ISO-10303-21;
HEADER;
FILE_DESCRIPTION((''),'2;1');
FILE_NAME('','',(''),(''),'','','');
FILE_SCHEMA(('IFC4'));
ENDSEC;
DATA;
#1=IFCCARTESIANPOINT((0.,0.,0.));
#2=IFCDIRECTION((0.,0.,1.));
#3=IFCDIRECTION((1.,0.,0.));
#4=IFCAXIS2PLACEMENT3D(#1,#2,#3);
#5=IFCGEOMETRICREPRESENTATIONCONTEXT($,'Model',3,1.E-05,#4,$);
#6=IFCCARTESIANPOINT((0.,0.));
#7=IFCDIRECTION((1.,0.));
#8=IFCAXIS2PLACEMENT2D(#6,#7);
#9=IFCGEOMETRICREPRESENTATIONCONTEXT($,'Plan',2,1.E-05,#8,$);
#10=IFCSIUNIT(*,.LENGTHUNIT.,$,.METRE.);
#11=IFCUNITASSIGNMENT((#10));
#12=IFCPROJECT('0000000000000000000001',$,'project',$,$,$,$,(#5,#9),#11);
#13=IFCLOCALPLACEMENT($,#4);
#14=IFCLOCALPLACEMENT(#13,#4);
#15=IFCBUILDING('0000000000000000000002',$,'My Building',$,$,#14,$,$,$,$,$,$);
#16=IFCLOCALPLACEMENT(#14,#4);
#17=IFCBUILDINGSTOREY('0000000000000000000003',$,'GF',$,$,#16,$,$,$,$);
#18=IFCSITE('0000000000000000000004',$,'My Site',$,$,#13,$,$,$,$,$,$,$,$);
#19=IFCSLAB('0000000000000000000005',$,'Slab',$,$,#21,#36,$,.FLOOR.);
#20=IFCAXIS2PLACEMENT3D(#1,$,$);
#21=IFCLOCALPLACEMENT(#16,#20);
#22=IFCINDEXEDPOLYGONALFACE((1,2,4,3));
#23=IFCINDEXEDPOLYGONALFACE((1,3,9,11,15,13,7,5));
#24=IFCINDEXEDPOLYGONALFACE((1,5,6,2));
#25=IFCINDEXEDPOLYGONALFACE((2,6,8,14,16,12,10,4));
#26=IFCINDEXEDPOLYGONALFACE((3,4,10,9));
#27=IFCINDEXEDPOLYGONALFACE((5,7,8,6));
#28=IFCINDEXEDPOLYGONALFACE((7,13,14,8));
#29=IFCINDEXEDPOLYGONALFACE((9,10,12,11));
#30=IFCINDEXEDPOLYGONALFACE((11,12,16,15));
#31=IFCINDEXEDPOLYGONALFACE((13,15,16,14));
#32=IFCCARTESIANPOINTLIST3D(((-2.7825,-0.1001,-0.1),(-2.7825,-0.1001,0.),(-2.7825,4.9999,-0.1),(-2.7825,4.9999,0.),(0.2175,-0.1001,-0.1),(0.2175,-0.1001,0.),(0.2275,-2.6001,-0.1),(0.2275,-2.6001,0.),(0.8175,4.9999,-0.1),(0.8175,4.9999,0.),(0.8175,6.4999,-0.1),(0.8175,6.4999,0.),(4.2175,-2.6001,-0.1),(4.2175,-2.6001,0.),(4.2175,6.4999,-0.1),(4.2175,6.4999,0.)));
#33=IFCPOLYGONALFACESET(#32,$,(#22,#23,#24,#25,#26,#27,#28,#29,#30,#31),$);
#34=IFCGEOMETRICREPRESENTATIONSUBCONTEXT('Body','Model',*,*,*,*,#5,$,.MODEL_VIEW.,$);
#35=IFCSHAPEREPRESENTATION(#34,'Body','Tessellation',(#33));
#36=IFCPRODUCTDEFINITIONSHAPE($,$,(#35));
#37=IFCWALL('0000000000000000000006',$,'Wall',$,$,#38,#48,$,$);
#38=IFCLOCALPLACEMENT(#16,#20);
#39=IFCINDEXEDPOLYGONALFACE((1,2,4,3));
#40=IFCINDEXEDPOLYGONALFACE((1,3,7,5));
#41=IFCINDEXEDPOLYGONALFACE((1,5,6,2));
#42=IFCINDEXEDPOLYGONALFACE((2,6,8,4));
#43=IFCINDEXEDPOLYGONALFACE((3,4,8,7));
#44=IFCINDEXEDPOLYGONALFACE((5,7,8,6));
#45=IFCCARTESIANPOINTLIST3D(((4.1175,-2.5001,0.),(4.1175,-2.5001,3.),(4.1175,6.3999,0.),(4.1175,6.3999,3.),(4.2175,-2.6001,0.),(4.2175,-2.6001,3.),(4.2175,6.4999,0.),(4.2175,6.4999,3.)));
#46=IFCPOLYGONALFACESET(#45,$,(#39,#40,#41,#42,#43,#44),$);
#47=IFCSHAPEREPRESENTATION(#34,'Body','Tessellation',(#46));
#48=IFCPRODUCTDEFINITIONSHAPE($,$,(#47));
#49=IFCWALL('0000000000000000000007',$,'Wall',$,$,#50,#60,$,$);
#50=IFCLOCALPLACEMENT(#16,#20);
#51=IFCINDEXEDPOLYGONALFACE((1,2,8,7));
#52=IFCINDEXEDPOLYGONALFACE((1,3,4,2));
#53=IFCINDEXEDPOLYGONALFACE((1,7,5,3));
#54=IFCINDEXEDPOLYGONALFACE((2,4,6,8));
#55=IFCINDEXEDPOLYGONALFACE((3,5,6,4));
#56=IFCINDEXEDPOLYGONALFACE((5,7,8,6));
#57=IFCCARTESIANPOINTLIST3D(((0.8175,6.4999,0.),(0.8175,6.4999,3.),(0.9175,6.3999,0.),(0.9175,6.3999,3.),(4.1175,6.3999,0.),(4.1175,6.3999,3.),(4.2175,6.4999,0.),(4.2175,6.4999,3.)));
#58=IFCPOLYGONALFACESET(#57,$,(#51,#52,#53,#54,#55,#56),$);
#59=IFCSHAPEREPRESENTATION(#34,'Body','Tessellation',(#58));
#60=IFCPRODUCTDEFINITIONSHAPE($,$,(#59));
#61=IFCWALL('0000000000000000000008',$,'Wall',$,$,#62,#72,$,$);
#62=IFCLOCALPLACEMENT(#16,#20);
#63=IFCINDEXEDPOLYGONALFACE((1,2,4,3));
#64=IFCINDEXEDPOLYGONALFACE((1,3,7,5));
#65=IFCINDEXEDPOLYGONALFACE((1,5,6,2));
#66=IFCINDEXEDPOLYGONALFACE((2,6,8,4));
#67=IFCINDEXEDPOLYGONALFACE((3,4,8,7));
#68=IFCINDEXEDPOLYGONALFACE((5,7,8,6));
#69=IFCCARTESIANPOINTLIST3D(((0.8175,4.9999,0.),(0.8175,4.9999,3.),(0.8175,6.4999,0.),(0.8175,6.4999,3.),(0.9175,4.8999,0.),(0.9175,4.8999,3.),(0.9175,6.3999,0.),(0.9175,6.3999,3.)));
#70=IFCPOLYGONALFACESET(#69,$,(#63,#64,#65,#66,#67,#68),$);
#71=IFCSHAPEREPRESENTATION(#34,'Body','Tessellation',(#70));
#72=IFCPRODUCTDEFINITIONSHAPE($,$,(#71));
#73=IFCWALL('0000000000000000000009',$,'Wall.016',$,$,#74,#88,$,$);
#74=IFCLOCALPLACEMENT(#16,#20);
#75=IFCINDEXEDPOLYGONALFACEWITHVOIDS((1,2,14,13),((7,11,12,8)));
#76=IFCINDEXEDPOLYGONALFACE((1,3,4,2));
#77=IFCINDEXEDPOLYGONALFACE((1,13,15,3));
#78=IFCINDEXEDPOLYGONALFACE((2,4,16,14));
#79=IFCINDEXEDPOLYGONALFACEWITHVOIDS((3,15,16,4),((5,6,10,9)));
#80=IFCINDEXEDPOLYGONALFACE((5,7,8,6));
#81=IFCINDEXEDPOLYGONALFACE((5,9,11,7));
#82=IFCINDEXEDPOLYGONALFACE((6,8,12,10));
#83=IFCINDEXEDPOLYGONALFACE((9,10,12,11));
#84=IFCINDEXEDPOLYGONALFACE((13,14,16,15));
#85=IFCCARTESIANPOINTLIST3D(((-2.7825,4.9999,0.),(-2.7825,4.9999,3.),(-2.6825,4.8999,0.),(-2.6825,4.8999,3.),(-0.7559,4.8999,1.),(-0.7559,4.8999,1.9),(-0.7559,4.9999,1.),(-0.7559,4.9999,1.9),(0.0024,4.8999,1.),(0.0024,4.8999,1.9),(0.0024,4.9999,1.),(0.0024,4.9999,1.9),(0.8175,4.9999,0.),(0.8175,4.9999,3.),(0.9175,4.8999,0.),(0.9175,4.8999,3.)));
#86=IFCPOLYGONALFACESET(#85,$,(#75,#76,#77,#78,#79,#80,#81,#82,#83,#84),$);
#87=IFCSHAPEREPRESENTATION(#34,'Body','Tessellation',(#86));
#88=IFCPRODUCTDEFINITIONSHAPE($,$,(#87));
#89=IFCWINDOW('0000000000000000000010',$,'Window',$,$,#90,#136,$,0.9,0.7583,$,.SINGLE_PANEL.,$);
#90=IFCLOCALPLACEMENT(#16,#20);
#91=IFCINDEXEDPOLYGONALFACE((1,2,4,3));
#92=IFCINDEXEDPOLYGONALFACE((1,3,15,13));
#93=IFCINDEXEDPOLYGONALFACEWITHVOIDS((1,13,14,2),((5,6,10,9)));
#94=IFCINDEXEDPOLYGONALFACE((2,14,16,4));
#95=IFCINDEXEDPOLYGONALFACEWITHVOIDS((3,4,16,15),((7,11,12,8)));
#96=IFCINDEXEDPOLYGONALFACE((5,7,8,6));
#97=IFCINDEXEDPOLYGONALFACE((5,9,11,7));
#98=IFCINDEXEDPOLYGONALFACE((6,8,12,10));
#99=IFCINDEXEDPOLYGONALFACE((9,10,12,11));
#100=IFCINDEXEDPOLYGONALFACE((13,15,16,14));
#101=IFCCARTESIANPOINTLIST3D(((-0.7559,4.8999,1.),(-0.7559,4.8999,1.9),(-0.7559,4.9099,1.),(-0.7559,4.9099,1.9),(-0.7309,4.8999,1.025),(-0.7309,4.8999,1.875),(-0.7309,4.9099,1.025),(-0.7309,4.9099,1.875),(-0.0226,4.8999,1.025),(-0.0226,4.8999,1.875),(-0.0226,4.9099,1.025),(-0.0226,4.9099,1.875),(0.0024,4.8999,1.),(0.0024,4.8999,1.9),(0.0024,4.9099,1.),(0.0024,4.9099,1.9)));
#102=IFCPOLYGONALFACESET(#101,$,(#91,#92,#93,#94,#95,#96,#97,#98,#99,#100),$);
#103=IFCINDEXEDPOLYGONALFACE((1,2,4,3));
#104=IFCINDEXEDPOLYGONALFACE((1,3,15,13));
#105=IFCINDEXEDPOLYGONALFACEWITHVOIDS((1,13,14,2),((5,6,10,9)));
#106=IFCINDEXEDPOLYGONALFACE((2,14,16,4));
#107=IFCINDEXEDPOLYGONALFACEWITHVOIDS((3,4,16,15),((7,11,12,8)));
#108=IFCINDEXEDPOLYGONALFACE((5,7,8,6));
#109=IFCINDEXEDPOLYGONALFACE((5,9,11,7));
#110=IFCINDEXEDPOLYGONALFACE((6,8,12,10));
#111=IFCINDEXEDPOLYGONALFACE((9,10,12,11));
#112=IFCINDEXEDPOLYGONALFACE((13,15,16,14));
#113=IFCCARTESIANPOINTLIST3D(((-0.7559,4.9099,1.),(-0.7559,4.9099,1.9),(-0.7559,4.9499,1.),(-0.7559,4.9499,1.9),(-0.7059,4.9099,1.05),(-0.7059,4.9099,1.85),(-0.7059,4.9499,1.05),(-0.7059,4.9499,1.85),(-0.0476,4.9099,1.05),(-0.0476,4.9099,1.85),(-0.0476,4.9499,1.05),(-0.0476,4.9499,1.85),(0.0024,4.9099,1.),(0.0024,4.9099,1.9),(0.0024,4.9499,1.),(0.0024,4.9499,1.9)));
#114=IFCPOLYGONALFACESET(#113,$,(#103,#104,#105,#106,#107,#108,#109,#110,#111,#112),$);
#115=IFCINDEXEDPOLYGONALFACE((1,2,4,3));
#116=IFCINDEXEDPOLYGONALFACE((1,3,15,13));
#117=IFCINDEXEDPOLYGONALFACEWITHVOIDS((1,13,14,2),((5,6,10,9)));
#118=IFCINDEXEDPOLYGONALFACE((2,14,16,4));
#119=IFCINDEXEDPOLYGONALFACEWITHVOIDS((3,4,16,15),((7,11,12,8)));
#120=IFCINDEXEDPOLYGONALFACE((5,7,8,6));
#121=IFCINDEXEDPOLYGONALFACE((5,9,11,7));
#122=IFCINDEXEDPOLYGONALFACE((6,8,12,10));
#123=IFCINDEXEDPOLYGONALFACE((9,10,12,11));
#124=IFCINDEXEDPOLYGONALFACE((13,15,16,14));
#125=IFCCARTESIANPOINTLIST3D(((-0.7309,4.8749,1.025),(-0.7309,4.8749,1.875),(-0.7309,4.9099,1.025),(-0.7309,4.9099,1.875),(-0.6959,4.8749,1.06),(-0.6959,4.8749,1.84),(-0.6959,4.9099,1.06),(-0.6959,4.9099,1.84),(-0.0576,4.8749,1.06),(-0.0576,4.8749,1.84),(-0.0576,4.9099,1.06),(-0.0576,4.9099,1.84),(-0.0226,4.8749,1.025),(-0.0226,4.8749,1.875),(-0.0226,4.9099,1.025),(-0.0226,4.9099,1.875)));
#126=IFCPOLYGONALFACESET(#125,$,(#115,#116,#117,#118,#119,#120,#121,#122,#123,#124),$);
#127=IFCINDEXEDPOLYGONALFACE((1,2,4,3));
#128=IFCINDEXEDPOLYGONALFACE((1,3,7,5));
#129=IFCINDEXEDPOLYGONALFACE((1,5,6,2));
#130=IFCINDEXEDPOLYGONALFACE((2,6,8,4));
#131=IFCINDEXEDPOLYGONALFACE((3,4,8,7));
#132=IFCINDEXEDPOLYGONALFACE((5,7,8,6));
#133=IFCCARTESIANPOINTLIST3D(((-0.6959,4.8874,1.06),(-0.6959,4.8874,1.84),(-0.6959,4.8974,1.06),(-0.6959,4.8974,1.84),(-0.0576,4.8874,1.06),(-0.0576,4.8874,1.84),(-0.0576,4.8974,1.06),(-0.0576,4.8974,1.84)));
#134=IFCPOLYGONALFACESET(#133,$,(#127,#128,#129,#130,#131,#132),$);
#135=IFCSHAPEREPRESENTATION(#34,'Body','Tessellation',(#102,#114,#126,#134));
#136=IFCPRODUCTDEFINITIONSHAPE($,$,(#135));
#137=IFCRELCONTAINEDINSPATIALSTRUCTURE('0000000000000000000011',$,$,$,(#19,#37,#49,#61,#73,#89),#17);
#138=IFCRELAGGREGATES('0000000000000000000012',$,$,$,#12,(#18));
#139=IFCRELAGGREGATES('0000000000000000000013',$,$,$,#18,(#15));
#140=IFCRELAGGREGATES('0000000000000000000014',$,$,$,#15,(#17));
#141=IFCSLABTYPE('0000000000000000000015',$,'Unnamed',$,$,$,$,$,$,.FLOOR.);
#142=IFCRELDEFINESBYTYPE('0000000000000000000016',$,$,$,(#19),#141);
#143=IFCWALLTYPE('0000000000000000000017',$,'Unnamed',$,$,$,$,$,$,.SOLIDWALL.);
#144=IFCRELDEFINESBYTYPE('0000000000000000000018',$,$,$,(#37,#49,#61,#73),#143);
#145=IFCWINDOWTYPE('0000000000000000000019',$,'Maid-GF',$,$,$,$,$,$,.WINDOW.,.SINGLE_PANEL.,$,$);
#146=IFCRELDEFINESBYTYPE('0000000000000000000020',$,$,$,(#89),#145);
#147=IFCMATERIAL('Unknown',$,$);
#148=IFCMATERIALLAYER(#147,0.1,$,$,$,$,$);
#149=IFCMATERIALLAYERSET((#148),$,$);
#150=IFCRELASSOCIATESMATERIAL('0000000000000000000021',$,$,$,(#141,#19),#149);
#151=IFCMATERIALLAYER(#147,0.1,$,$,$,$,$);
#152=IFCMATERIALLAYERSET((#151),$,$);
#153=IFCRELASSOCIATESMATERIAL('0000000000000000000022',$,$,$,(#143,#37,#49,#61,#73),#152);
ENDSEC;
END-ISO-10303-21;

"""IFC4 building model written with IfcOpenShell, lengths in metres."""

from ifc_helpers import new_model, entity, si_unit, frame, origin_with_axes, origin_2d_with_axis, place, context, subcontext, project, spatial, line, indexed_curve, outline, extrude, shape, source, transform, mapped, material, layer, layer_set, layer_usage, type_object, type_shapes, element, fill, save


model = new_model("IFC4")

# Units and contexts
model_context = context("Model", 3, precision=1e-05, world=origin_with_axes())
plan_context = context("Plan", 2, precision=1e-05, world=origin_2d_with_axis())
body_context_1 = subcontext(model_context, "Body", "Model", "MODEL_VIEW")
body_context_2 = subcontext(plan_context, "Body", "Plan", "PLAN_VIEW")
ifc_project = project(units=[si_unit("LENGTHUNIT", "METRE")], contexts=[model_context, plan_context])

# Site, building, storey
site_placement = place(None, origin_with_axes())
site = spatial("IfcSite", under=ifc_project, at=site_placement, Name="My Site")
building_placement = place(site_placement, origin_with_axes())
building = spatial("IfcBuilding", under=site, at=building_placement, Name="My Building")
storey_placement = place(building_placement, origin_with_axes())
storey = spatial("IfcBuildingStorey", under=building, at=storey_placement, Name="GF")

# Slab
ifc_material = material(Name="Unknown")
ifc_layer_1 = layer(ifc_material, 0.1)
ifc_layer_set_1 = layer_set([ifc_layer_1])
ifc_layer_usage_1 = layer_usage(ifc_layer_set_1, "AXIS3", "POSITIVE", -0.05)
slab_type_1 = type_object("IfcSlabType", Name="Unnamed", PredefinedType="FLOOR", material=ifc_layer_set_1)
slab_1_placement = place(storey_placement, frame((0.8175, 6.4999, -0.05), z_axis=(0.0, 0.0, 1.0), x_axis=(1.0, 0.0, 0.0)))
element("IfcSlab", 1, at=slab_1_placement, inside=storey, type_object=slab_type_1, material=ifc_layer_usage_1, Name="Slab", PredefinedType="FLOOR", context=body_context_1, shape_type="SweptSolid", body=[
    extrude(outline(indexed_curve([(0.0, 0.0), (3.4, 0.0), (3.4, -9.1), (-0.59, -9.1), (-0.6, -6.6), (-3.6, -6.6), (-3.6, -1.5), (0.0, -1.5), (0.0, 0.0)])), frame((0.0, 0.0, -0.05), z_axis=(0.0, 0.0, 1.0), x_axis=(1.0, 0.0, 0.0)), (0.0, 0.0, 1.0), 0.1),
])

# Shared definitions
ifc_layer_2 = layer(ifc_material, 0.1)
ifc_layer_set_2 = layer_set([ifc_layer_2])
wall_type = type_object("IfcWallType", Name="Unnamed", PredefinedType="SOLIDWALL", material=ifc_layer_set_2)

# Walls
ifc_layer_usage_2 = layer_usage(ifc_layer_set_2, "AXIS2", "POSITIVE", 0.0)
wall_1_placement = place(storey_placement, frame((4.2175, -2.6001, 0.0), z_axis=(0.0, 0.0, 1.0), x_axis=(0.0, 1.0, 0.0)))
element("IfcWall", 2, at=wall_1_placement, inside=storey, type_object=wall_type, material=ifc_layer_usage_2, Name="Wall", context=body_context_1, shape_type="SweptSolid", body=[
    extrude(outline(indexed_curve([(0.0, 0.0), (0.1, 0.1), (9.0, 0.1), (9.1, 0.0)], segments=[line(1, 2, 3, 4, 1)])), origin_with_axes(), (0.0, 0.0, 1.0), 3.0),
])
ifc_layer_usage_3 = layer_usage(ifc_layer_set_2, "AXIS2", "POSITIVE", 0.0)
wall_2_placement = place(storey_placement, frame((4.2175, 6.4999, 0.0), z_axis=(0.0, 0.0, 1.0), x_axis=(-1.0, 0.0, 0.0)))
element("IfcWall", 3, at=wall_2_placement, inside=storey, type_object=wall_type, material=ifc_layer_usage_3, Name="Wall", context=body_context_1, shape_type="SweptSolid", body=[
    extrude(outline(indexed_curve([(0.0, 0.0), (0.1, 0.1), (3.3, 0.1), (3.4, 0.0)], segments=[line(1, 2, 3, 4, 1)])), origin_with_axes(), (0.0, 0.0, 1.0), 3.0),
])
ifc_layer_usage_4 = layer_usage(ifc_layer_set_2, "AXIS2", "POSITIVE", 0.0)
wall_3_placement = place(storey_placement, frame((0.8175, 6.4999, 0.0), z_axis=(0.0, 0.0, 1.0), x_axis=(0.0, -1.0, 0.0)))
element("IfcWall", 4, at=wall_3_placement, inside=storey, type_object=wall_type, material=ifc_layer_usage_4, Name="Wall", context=body_context_1, shape_type="SweptSolid", body=[
    extrude(outline(indexed_curve([(0.0, 0.0), (0.1, 0.1), (1.6, 0.1), (1.5, 0.0)], segments=[line(1, 2, 3, 4, 1)])), origin_with_axes(), (0.0, 0.0, 1.0), 3.0),
])

# Wall, opening, window
ifc_layer_usage_5 = layer_usage(ifc_layer_set_2, "AXIS2", "POSITIVE", 0.0)
wall_4_placement = place(storey_placement, frame((0.8175, 4.9999, 0.0), z_axis=(0.0, 0.0, 1.0), x_axis=(-1.0, 0.0, 0.0)))
wall_4 = element("IfcWall", 5, at=wall_4_placement, inside=storey, type_object=wall_type, material=ifc_layer_usage_5, Name="Wall.016", context=body_context_1, shape_type="SweptSolid", body=[
    extrude(outline(indexed_curve([(0.0, 0.0), (-0.1, 0.1), (3.5, 0.1), (3.6, 0.0)], segments=[line(1, 2, 3, 4, 1)])), origin_with_axes(), (0.0, 0.0, 1.0), 3.0),
])
shared_shape_1 = source(origin_with_axes(), body_context_1, "Body", "SweptSolid", [
    extrude(outline(indexed_curve([(0.0, 0.0), (0.7583, 0.0), (0.7583, 0.9), (0.0, 0.9)], segments=[line(1, 2, 3, 4, 1)])), frame((0.0, -0.6, 0.0), z_axis=(0.0, -1.0, 0.0), x_axis=(1.0, 0.0, 0.0)), (0.0, 0.0, -1.0), 1.2),
])
opening_1_placement = place(wall_4_placement, frame((0.8151, 0.0, 1.0), z_axis=(0.0, 0.0, 1.0), x_axis=(1.0, 0.0, 0.0)))
opening_1 = element("IfcOpeningElement", 6, at=opening_1_placement, cuts=wall_4, PredefinedType="OPENING", context=body_context_1, shape_type="MappedRepresentation", body=[
    mapped(shared_shape_1, transform((0.0, 0.0, 0.0), x_axis=(1.0, 0.0, 0.0), y_axis=(0.0, 1.0, 0.0), z_axis=(0.0, 0.0, 1.0), scale=1.0)),
])
window_type_1 = type_object("IfcWindowType", Name="Maid-GF", PartitioningType="SINGLE_PANEL", PredefinedType="WINDOW")
shared_shape_2 = source(origin_with_axes(), body_context_1, "Body", "SweptSolid", [
    extrude(outline(indexed_curve([(0.0, 0.0), (0.7583, 0.0), (0.7583, 0.9), (0.0, 0.9)], segments=[line(1, 2, 3, 4, 1)]), holes=[indexed_curve([(0.025, 0.025), (0.7333, 0.025), (0.7333, 0.875), (0.025, 0.875)], segments=[line(1, 2, 3, 4, 1)])]), frame((0.0, 0.09, 0.0), z_axis=(0.0, -1.0, 0.0), x_axis=(1.0, 0.0, 0.0)), (0.0, 0.0, -1.0), 0.01),
    extrude(outline(indexed_curve([(0.0, 0.0), (0.7583, 0.0), (0.7583, 0.9), (0.0, 0.9)], segments=[line(1, 2, 3, 4, 1)]), holes=[indexed_curve([(0.05, 0.05), (0.7083, 0.05), (0.7083, 0.85), (0.05, 0.85)], segments=[line(1, 2, 3, 4, 1)])]), frame((0.0, 0.05, 0.0), z_axis=(0.0, -1.0, 0.0), x_axis=(1.0, 0.0, 0.0)), (0.0, 0.0, -1.0), 0.04),
    extrude(outline(indexed_curve([(0.0, 0.0), (0.7083, 0.0), (0.7083, 0.85), (0.0, 0.85)], segments=[line(1, 2, 3, 4, 1)]), holes=[indexed_curve([(0.035, 0.035), (0.6733, 0.035), (0.6733, 0.815), (0.035, 0.815)], segments=[line(1, 2, 3, 4, 1)])]), frame((0.025, 0.09, 0.025), z_axis=(0.0, -1.0, 0.0), x_axis=(1.0, 0.0, 0.0)), (0.0, 0.0, -1.0), 0.035),
    extrude(outline(indexed_curve([(0.035, 0.035), (0.6733, 0.035), (0.6733, 0.815), (0.035, 0.815)], segments=[line(1, 2, 3, 4, 1)])), frame((0.025, 0.1025, 0.025), z_axis=(0.0, -1.0, 0.0), x_axis=(1.0, 0.0, 0.0)), (0.0, 0.0, -1.0), 0.01),
])
shared_shape_3 = source(origin_with_axes(), body_context_2, "Body", "Curve2D", [
    entity("IfcIndexedPolyCurve", entity("IfcCartesianPointList2D", [[0.05, 0.05], [0.7083, 0.05]])),
    entity("IfcIndexedPolyCurve", entity("IfcCartesianPointList2D", [[0.0, 0.1], [0.025, 0.1], [0.025, 0.09], [0.05, 0.09], [0.05, 0.05], [0.0, 0.05]]), [entity("IfcLineIndex", [1, 2, 3, 4, 5, 6, 1])]),
    entity("IfcIndexedPolyCurve", entity("IfcCartesianPointList2D", [[0.7583, 0.1], [0.7333, 0.1], [0.7333, 0.09], [0.7083, 0.09], [0.7083, 0.05], [0.7583, 0.05]]), [entity("IfcLineIndex", [1, 2, 3, 4, 5, 6, 1])]),
    entity("IfcIndexedPolyCurve", entity("IfcCartesianPointList2D", [[0.025, 0.09], [0.06, 0.09], [0.06, 0.125], [0.025, 0.125]]), [entity("IfcLineIndex", [1, 2, 3, 4, 1])]),
    entity("IfcIndexedPolyCurve", entity("IfcCartesianPointList2D", [[0.7333, 0.09], [0.6983, 0.09], [0.6983, 0.125], [0.7333, 0.125]]), [entity("IfcLineIndex", [1, 2, 3, 4, 1])]),
    entity("IfcIndexedPolyCurve", entity("IfcCartesianPointList2D", [[0.06, 0.09], [0.6983, 0.09]])),
    entity("IfcIndexedPolyCurve", entity("IfcCartesianPointList2D", [[0.06, 0.125], [0.6983, 0.125]])),
    entity("IfcIndexedPolyCurve", entity("IfcCartesianPointList2D", [[0.06, 0.1075], [0.6983, 0.1075]])),
])
type_shapes(window_type_1, [shared_shape_2, shared_shape_3])
window_1_placement = place(opening_1_placement, frame((0.0, 0.0, 0.0), z_axis=(0.0, 0.0, 1.0), x_axis=(1.0, 0.0, 0.0)))
window_1 = element("IfcWindow", 7, at=window_1_placement, inside=storey, type_object=window_type_1, Name="Window", OverallHeight=0.9, OverallWidth=0.7583, PartitioningType="SINGLE_PANEL", shapes=[
    shape(body_context_1, "Body", "MappedRepresentation", [mapped(shared_shape_2, transform((0.0, 0.0, 0.0), x_axis=(1.0, 0.0, 0.0), y_axis=(0.0, 1.0, 0.0), z_axis=(0.0, 0.0, 1.0), scale=1.0))]),
    shape(body_context_2, "Body", "MappedRepresentation", [mapped(shared_shape_3, transform((0.0, 0.0, 0.0), x_axis=(1.0, 0.0, 0.0), y_axis=(0.0, 1.0, 0.0), z_axis=(0.0, 0.0, 1.0), scale=1.0))]),
])
fill(opening_1, window_1)

save(model, "model.ifc")
